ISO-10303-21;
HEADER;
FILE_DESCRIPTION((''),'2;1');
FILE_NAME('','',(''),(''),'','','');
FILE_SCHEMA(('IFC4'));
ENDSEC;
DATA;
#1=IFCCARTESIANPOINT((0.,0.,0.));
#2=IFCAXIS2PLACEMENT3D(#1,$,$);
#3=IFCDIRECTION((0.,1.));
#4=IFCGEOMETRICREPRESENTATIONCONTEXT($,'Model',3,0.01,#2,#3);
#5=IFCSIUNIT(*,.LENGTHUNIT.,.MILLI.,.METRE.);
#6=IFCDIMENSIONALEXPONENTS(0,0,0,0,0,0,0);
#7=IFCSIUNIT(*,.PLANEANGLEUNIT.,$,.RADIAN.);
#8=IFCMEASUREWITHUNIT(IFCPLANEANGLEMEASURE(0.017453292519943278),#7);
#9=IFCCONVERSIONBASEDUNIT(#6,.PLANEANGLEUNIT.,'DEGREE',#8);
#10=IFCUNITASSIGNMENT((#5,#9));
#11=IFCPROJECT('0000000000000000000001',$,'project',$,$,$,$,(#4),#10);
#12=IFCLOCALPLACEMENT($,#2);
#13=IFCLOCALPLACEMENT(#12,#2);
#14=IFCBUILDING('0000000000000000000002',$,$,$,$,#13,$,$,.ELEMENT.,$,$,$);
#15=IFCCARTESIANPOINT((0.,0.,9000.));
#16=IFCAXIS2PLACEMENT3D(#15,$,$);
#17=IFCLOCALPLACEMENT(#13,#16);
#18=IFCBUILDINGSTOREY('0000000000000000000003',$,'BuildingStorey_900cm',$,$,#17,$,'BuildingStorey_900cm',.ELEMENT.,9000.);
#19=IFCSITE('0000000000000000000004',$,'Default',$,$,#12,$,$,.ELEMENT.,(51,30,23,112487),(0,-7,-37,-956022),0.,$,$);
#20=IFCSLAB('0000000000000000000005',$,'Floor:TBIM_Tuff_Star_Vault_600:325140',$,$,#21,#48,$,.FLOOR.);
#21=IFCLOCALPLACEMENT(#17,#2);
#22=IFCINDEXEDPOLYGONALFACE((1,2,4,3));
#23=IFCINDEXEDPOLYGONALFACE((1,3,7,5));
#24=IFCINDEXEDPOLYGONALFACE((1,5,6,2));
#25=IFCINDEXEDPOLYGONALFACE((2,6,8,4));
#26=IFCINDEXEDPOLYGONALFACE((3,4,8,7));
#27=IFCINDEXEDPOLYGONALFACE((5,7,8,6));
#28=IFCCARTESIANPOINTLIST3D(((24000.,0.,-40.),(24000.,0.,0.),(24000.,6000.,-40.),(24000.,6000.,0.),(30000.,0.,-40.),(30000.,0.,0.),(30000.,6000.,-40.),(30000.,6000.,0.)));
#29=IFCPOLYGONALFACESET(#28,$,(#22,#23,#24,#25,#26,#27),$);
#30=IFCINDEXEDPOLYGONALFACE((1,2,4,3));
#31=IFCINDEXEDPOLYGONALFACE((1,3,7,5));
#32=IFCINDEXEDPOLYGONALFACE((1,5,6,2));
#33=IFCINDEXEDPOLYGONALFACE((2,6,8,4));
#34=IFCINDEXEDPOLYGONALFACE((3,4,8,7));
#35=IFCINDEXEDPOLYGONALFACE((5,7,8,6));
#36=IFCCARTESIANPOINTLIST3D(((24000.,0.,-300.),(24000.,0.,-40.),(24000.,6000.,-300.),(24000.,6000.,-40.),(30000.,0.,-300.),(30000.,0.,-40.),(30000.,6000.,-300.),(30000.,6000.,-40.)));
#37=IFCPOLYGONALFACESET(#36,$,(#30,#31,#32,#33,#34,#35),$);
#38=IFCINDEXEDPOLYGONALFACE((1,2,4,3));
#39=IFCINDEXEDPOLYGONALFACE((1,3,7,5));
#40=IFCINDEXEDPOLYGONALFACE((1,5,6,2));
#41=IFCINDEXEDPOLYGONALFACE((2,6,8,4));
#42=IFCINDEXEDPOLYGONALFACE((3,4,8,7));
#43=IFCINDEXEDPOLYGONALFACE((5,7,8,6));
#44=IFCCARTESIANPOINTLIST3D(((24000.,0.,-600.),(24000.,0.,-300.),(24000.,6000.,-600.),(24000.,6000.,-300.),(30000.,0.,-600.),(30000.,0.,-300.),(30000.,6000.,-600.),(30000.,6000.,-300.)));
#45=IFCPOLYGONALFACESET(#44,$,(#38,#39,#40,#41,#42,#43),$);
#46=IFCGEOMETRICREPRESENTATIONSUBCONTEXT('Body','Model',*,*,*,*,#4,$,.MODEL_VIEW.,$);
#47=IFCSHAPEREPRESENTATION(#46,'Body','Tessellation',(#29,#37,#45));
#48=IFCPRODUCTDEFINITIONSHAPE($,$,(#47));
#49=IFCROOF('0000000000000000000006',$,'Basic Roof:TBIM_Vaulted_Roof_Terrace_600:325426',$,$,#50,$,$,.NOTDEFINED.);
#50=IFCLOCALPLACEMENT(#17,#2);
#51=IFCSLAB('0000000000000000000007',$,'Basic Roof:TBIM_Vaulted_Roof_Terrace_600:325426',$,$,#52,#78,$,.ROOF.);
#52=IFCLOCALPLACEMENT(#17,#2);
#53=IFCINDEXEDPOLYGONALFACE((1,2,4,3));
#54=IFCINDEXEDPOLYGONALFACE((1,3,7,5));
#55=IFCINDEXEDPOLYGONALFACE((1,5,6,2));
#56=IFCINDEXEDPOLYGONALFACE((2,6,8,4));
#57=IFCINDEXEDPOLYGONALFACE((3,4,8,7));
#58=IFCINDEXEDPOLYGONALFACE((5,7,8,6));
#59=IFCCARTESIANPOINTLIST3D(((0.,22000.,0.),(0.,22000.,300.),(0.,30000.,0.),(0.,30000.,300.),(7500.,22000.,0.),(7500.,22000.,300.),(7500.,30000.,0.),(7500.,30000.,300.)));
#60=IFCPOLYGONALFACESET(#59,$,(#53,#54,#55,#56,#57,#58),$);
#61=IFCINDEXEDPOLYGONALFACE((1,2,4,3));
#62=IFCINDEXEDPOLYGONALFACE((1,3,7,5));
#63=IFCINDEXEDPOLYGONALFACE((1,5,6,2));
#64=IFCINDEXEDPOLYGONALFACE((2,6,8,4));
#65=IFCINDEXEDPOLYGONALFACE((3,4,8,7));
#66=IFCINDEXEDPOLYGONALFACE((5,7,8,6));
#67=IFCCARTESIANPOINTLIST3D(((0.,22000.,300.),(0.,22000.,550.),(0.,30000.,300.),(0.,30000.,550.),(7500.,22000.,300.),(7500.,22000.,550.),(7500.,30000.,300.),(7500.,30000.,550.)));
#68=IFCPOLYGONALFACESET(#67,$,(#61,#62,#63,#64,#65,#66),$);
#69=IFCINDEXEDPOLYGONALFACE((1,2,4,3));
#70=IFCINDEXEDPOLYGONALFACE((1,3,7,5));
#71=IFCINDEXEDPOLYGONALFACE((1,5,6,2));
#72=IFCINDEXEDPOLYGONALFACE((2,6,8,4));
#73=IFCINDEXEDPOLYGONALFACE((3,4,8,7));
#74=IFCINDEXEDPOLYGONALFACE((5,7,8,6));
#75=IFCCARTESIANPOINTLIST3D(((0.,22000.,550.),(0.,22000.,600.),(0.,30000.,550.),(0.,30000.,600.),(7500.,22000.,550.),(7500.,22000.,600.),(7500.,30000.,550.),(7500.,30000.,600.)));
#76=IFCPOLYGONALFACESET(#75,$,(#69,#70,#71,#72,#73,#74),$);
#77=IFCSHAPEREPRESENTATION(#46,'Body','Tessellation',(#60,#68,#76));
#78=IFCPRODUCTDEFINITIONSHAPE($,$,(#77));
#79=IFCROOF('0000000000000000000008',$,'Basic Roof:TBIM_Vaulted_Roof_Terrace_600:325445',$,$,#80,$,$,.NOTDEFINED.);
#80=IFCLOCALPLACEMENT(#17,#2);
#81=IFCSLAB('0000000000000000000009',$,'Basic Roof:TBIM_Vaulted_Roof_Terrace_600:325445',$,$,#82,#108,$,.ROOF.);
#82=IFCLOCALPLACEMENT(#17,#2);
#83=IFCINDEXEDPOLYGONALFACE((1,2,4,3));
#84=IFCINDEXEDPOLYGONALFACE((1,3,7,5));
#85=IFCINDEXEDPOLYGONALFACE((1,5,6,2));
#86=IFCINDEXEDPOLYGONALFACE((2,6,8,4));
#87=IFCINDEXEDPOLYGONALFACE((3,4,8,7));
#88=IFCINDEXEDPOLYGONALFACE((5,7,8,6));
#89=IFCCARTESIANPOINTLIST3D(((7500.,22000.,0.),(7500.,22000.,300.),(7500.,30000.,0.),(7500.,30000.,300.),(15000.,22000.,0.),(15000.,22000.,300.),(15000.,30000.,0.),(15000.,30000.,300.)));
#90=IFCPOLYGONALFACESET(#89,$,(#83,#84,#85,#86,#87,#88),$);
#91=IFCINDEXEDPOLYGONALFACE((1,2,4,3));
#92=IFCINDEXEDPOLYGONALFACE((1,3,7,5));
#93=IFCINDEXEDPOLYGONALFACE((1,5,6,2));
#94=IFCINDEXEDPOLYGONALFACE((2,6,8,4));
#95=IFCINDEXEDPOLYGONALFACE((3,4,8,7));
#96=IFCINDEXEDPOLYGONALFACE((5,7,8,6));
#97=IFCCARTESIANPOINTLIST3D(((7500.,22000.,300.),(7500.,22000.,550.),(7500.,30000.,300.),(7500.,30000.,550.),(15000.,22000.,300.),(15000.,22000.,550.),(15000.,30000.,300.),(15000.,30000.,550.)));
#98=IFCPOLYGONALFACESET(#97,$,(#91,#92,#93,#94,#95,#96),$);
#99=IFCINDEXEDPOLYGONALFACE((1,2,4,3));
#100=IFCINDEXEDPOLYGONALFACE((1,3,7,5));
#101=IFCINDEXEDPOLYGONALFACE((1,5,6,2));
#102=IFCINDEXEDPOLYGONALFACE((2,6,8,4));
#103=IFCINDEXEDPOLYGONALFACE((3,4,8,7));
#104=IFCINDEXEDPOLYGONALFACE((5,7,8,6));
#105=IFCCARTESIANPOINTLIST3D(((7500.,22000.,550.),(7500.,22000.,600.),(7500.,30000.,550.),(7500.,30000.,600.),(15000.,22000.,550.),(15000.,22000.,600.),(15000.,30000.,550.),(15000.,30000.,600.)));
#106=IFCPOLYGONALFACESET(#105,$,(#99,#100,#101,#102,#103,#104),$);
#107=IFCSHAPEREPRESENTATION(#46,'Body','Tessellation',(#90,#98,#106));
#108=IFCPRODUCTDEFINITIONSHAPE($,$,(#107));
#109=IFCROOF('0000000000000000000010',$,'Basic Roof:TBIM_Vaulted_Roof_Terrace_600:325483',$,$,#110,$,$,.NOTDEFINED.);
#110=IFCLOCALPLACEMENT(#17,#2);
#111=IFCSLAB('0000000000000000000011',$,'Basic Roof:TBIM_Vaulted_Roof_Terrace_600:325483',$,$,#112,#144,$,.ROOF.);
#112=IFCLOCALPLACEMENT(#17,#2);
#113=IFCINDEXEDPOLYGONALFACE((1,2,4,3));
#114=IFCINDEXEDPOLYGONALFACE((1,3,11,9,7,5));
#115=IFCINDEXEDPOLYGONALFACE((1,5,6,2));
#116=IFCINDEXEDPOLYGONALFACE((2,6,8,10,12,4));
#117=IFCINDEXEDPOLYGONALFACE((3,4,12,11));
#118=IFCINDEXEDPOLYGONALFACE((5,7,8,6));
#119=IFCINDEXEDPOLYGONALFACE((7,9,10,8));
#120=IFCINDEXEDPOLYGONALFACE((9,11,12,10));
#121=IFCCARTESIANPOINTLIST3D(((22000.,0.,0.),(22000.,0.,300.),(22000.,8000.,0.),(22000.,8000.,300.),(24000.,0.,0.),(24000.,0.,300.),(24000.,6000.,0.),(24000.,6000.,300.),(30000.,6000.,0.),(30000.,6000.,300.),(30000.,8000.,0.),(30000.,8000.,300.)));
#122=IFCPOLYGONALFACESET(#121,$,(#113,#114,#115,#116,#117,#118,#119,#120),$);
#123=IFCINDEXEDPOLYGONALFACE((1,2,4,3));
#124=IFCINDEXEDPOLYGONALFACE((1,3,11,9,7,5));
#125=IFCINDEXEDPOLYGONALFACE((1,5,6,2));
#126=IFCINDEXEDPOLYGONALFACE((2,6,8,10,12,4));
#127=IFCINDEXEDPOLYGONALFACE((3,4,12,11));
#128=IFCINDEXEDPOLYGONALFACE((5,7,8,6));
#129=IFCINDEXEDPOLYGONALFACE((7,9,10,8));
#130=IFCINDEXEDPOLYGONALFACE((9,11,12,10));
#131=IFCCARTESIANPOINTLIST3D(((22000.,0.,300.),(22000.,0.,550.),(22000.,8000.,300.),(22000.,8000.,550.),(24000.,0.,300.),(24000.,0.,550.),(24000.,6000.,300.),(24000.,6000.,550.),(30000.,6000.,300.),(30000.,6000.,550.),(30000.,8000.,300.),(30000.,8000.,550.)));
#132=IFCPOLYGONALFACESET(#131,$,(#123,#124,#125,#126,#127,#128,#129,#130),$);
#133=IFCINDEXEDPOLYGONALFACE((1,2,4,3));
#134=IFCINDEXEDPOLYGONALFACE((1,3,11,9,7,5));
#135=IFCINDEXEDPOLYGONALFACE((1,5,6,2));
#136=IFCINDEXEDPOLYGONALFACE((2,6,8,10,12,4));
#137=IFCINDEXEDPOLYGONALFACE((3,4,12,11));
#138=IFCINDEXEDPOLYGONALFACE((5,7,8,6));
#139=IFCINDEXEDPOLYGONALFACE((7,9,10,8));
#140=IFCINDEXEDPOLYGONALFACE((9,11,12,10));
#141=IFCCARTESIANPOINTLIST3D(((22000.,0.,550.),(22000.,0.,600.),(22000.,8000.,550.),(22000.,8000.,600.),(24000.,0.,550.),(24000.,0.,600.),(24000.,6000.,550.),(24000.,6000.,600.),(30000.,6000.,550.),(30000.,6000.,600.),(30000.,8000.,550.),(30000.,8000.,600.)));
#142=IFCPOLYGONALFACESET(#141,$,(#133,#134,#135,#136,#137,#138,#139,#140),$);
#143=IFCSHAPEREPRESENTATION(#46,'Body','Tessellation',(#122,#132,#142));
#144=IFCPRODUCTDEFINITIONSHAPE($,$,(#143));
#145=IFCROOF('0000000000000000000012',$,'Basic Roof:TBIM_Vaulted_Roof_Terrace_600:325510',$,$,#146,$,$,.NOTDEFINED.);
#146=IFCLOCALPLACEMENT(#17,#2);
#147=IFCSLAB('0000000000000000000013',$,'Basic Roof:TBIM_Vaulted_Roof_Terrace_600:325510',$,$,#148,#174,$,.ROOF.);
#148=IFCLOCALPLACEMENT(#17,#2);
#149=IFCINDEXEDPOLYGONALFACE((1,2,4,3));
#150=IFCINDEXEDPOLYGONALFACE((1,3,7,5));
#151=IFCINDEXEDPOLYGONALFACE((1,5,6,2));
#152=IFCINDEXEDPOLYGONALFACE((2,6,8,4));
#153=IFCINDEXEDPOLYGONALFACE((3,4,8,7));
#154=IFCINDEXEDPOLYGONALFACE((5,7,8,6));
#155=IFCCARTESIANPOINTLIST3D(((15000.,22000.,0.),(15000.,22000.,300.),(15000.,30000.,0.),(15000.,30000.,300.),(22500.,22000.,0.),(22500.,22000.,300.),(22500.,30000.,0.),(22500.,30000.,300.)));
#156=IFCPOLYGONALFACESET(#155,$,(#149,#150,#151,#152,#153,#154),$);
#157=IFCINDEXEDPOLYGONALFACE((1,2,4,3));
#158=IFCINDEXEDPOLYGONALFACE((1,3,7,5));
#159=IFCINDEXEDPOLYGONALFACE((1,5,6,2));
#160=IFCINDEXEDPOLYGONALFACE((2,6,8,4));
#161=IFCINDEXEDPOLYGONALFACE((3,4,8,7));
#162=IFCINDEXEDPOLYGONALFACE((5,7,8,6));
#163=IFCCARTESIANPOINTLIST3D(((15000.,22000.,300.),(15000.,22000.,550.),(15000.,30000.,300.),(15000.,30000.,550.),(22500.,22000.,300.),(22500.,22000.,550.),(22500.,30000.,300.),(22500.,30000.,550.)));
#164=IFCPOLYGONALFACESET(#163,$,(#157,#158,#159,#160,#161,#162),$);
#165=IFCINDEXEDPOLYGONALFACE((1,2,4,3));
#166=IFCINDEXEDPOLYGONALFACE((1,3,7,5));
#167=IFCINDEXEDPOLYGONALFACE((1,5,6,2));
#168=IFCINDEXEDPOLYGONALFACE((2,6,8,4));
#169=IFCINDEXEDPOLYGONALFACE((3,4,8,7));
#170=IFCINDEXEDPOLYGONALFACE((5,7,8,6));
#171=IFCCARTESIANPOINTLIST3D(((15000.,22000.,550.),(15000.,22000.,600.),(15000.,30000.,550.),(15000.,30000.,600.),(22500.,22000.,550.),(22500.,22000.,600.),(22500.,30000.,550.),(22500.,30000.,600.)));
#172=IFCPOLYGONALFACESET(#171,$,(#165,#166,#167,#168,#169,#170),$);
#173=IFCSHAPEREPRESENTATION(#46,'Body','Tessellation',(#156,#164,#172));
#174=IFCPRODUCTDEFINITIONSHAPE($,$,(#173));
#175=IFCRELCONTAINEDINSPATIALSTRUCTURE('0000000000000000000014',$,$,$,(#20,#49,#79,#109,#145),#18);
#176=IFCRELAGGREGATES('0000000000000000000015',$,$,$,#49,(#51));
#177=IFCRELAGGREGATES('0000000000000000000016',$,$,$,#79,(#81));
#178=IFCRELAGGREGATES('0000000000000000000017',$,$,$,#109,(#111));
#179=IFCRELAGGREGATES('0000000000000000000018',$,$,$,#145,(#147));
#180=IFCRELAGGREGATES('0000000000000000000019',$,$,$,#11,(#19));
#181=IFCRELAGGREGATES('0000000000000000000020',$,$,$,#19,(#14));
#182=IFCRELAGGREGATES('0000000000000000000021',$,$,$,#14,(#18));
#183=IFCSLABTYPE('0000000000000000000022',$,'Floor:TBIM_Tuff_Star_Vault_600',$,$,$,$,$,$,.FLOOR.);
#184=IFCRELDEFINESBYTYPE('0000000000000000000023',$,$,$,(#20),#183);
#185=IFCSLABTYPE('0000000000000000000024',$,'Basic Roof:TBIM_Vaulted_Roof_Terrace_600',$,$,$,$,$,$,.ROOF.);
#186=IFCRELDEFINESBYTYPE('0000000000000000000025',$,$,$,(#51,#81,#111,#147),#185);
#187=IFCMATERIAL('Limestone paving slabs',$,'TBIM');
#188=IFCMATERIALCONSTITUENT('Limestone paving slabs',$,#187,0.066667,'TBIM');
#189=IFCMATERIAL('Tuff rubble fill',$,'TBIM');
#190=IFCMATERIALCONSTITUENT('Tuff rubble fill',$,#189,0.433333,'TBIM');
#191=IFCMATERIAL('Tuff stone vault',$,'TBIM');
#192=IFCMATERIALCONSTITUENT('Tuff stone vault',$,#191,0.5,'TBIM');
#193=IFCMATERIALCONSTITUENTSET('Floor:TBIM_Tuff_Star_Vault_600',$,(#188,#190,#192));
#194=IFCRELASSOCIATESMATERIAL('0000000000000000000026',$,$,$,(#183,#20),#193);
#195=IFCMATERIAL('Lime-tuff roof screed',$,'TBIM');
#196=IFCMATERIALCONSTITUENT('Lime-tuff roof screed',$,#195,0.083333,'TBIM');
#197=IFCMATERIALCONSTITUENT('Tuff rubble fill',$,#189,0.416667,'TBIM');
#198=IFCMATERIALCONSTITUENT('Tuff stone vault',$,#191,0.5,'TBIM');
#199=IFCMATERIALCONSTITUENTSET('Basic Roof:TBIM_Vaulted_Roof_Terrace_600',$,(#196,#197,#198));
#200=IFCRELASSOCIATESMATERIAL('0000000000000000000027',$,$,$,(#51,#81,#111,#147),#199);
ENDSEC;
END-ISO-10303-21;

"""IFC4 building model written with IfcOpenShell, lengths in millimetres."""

from ifc_helpers import new_model, entity, si_unit, converted_unit, direction, frame, origin, place, context, subcontext, project, spatial, indexed_curve, outline, extrude, material, constituent, constituent_set, type_object, element, aggregate, save


model = new_model("IFC4")

# Units and contexts
model_context = context("Model", 3, precision=0.01, world=origin(), true_north=direction((0.0, 1.0)))
body_context = subcontext(model_context, "Body", "Model", "MODEL_VIEW")
ifc_project = project(units=[si_unit("LENGTHUNIT", "METRE", prefix="MILLI"), converted_unit("PLANEANGLEUNIT", "DEGREE", entity("IfcPlaneAngleMeasure", 0.017453292519943278), si_unit("PLANEANGLEUNIT", "RADIAN"), dimensions=[0, 0, 0, 0, 0, 0, 0])], contexts=[model_context])

# Site, building, storey
site_placement = place(None, origin())
site = spatial("IfcSite", under=ifc_project, at=site_placement, Name="Default", CompositionType="ELEMENT", RefLatitude=(51, 30, 23, 112487), RefLongitude=(0, -7, -37, -956022), RefElevation=0.0)
building_placement = place(site_placement, origin())
building = spatial("IfcBuilding", under=site, at=building_placement, CompositionType="ELEMENT")
storey_placement = place(building_placement, frame((0.0, 0.0, 9000.0)))
storey = spatial("IfcBuildingStorey", under=building, at=storey_placement, Name="BuildingStorey_900cm", LongName="BuildingStorey_900cm", CompositionType="ELEMENT", Elevation=9000.0)

# Slab
ifc_material_1 = material(Name="Limestone paving slabs", Category="TBIM")
ifc_constituent_1 = constituent(ifc_material_1, Name="Limestone paving slabs", Category="TBIM", fraction=0.066667)
ifc_material_2 = material(Name="Tuff rubble fill", Category="TBIM")
ifc_constituent_2 = constituent(ifc_material_2, Name="Tuff rubble fill", Category="TBIM", fraction=0.433333)
ifc_material_3 = material(Name="Tuff stone vault", Category="TBIM")
ifc_constituent_3 = constituent(ifc_material_3, Name="Tuff stone vault", Category="TBIM", fraction=0.5)
ifc_constituent_set_1 = constituent_set(constituents=[ifc_constituent_1, ifc_constituent_2, ifc_constituent_3], Name="Floor:TBIM_Tuff_Star_Vault_600")
slab_type_1 = type_object("IfcSlabType", Name="Floor:TBIM_Tuff_Star_Vault_600", PredefinedType="FLOOR", material=ifc_constituent_set_1)
slab_1_placement = place(storey_placement, origin())
element("IfcSlab", 1, at=slab_1_placement, inside=storey, type_object=slab_type_1, material=ifc_constituent_set_1, Name="Floor:TBIM_Tuff_Star_Vault_600:325140", PredefinedType="FLOOR", context=body_context, shape_type="SweptSolid", body=[
    extrude(outline(indexed_curve([(-3000.0, -3000.0), (3000.0, -3000.0), (3000.0, 3000.0), (-3000.0, 3000.0), (-3000.0, -3000.0)], self_intersect=False)), frame((27000.0, 3000.0, -40.0), z_axis=(0.0, 0.0, 1.0), x_axis=(-1.0, 0.0, 0.0)), (0.0, 0.0, 1.0), 40.0),
    extrude(outline(indexed_curve([(-3000.0, -3000.0), (3000.0, -3000.0), (3000.0, 3000.0), (-3000.0, 3000.0), (-3000.0, -3000.0)], self_intersect=False)), frame((27000.0, 3000.0, -300.0), z_axis=(0.0, 0.0, 1.0), x_axis=(-1.0, 0.0, 0.0)), (0.0, 0.0, 1.0), 260.0),
    extrude(outline(indexed_curve([(-3000.0, -3000.0), (3000.0, -3000.0), (3000.0, 3000.0), (-3000.0, 3000.0), (-3000.0, -3000.0)], self_intersect=False)), frame((27000.0, 3000.0, -600.0), z_axis=(0.0, 0.0, 1.0), x_axis=(-1.0, 0.0, 0.0)), (0.0, 0.0, 1.0), 300.0),
])

# Roofs, slabs
roof_1_placement = place(storey_placement, frame((0.0, 22000.0, 0.0)))
roof_1 = element("IfcRoof", 2, at=roof_1_placement, inside=storey, Name="Basic Roof:TBIM_Vaulted_Roof_Terrace_600:325426", PredefinedType="NOTDEFINED")
ifc_material_4 = material(Name="Lime-tuff roof screed", Category="TBIM")
ifc_constituent_4 = constituent(ifc_material_4, Name="Lime-tuff roof screed", Category="TBIM", fraction=0.083333)
ifc_constituent_5 = constituent(ifc_material_2, Name="Tuff rubble fill", Category="TBIM", fraction=0.416667)
ifc_constituent_6 = constituent(ifc_material_3, Name="Tuff stone vault", Category="TBIM", fraction=0.5)
ifc_constituent_set_2 = constituent_set(constituents=[ifc_constituent_4, ifc_constituent_5, ifc_constituent_6], Name="Basic Roof:TBIM_Vaulted_Roof_Terrace_600")
slab_type_2 = type_object("IfcSlabType", Name="Basic Roof:TBIM_Vaulted_Roof_Terrace_600", PredefinedType="ROOF")
slab_2_placement = place(roof_1_placement, origin())
slab_2 = element("IfcSlab", 3, at=slab_2_placement, type_object=slab_type_2, material=ifc_constituent_set_2, Name="Basic Roof:TBIM_Vaulted_Roof_Terrace_600:325426", PredefinedType="ROOF", context=body_context, shape_type="SweptSolid", body=[
    extrude(outline(indexed_curve([(-3750.0, 4000.0), (-3750.0, -4000.0), (3750.0, -4000.0), (3750.0, 4000.0), (-3750.0, 4000.0)], self_intersect=False)), frame((3750.0, 4000.0, 0.0)), (0.0, 0.0, 1.0), 300.0),
    extrude(outline(indexed_curve([(-3750.0, 4000.0), (-3750.0, -4000.0), (3750.0, -4000.0), (3750.0, 4000.0), (-3750.0, 4000.0)], self_intersect=False)), frame((3750.0, 4000.0, 300.0)), (0.0, 0.0, 1.0), 250.0),
    extrude(outline(indexed_curve([(-3750.0, 4000.0), (-3750.0, -4000.0), (3750.0, -4000.0), (3750.0, 4000.0), (-3750.0, 4000.0)], self_intersect=False)), frame((3750.0, 4000.0, 550.0)), (0.0, 0.0, 1.0), 50.0),
])
aggregate(roof_1, [slab_2])
roof_2_placement = place(storey_placement, frame((7500.0, 22000.0, 0.0)))
roof_2 = element("IfcRoof", 4, at=roof_2_placement, inside=storey, Name="Basic Roof:TBIM_Vaulted_Roof_Terrace_600:325445", PredefinedType="NOTDEFINED")
slab_3_placement = place(roof_2_placement, origin())
slab_3 = element("IfcSlab", 5, at=slab_3_placement, type_object=slab_type_2, material=ifc_constituent_set_2, Name="Basic Roof:TBIM_Vaulted_Roof_Terrace_600:325445", PredefinedType="ROOF", context=body_context, shape_type="SweptSolid", body=[
    extrude(outline(indexed_curve([(-3750.0, 4000.0), (-3750.0, -4000.0), (3750.0, -4000.0), (3750.0, 4000.0), (-3750.0, 4000.0)], self_intersect=False)), frame((3750.0, 4000.0, 0.0)), (0.0, 0.0, 1.0), 300.0),
    extrude(outline(indexed_curve([(-3750.0, 4000.0), (-3750.0, -4000.0), (3750.0, -4000.0), (3750.0, 4000.0), (-3750.0, 4000.0)], self_intersect=False)), frame((3750.0, 4000.0, 300.0)), (0.0, 0.0, 1.0), 250.0),
    extrude(outline(indexed_curve([(-3750.0, 4000.0), (-3750.0, -4000.0), (3750.0, -4000.0), (3750.0, 4000.0), (-3750.0, 4000.0)], self_intersect=False)), frame((3750.0, 4000.0, 550.0)), (0.0, 0.0, 1.0), 50.0),
])
aggregate(roof_2, [slab_3])
roof_3_placement = place(storey_placement, frame((22000.0, 0.0, 0.0)))
roof_3 = element("IfcRoof", 6, at=roof_3_placement, inside=storey, Name="Basic Roof:TBIM_Vaulted_Roof_Terrace_600:325483", PredefinedType="NOTDEFINED")
slab_4_placement = place(roof_3_placement, origin())
slab_4 = element("IfcSlab", 7, at=slab_4_placement, type_object=slab_type_2, material=ifc_constituent_set_2, Name="Basic Roof:TBIM_Vaulted_Roof_Terrace_600:325483", PredefinedType="ROOF", context=body_context, shape_type="SweptSolid", body=[
    extrude(outline(indexed_curve([(-4000.0, -4000.0), (-2000.0, -4000.0), (-2000.0, 2000.0), (4000.0, 2000.0), (4000.0, 4000.0), (-4000.0, 4000.0), (-4000.0, -4000.0)], self_intersect=False)), frame((4000.0, 4000.0, 0.0)), (0.0, 0.0, 1.0), 300.0),
    extrude(outline(indexed_curve([(-4000.0, -4000.0), (-2000.0, -4000.0), (-2000.0, 2000.0), (4000.0, 2000.0), (4000.0, 4000.0), (-4000.0, 4000.0), (-4000.0, -4000.0)], self_intersect=False)), frame((4000.0, 4000.0, 300.0)), (0.0, 0.0, 1.0), 250.0),
    extrude(outline(indexed_curve([(-4000.0, -4000.0), (-2000.0, -4000.0), (-2000.0, 2000.0), (4000.0, 2000.0), (4000.0, 4000.0), (-4000.0, 4000.0), (-4000.0, -4000.0)], self_intersect=False)), frame((4000.0, 4000.0, 550.0)), (0.0, 0.0, 1.0), 50.0),
])
aggregate(roof_3, [slab_4])
roof_4_placement = place(storey_placement, frame((15000.0, 22000.0, 0.0)))
roof_4 = element("IfcRoof", 8, at=roof_4_placement, inside=storey, Name="Basic Roof:TBIM_Vaulted_Roof_Terrace_600:325510", PredefinedType="NOTDEFINED")
slab_5_placement = place(roof_4_placement, origin())
slab_5 = element("IfcSlab", 9, at=slab_5_placement, type_object=slab_type_2, material=ifc_constituent_set_2, Name="Basic Roof:TBIM_Vaulted_Roof_Terrace_600:325510", PredefinedType="ROOF", context=body_context, shape_type="SweptSolid", body=[
    extrude(outline(indexed_curve([(-3750.0, 4000.0), (-3750.0, -4000.0), (3750.0, -4000.0), (3750.0, 4000.0), (-3750.0, 4000.0)], self_intersect=False)), frame((3750.0, 4000.0, 0.0)), (0.0, 0.0, 1.0), 300.0),
    extrude(outline(indexed_curve([(-3750.0, 4000.0), (-3750.0, -4000.0), (3750.0, -4000.0), (3750.0, 4000.0), (-3750.0, 4000.0)], self_intersect=False)), frame((3750.0, 4000.0, 300.0)), (0.0, 0.0, 1.0), 250.0),
    extrude(outline(indexed_curve([(-3750.0, 4000.0), (-3750.0, -4000.0), (3750.0, -4000.0), (3750.0, 4000.0), (-3750.0, 4000.0)], self_intersect=False)), frame((3750.0, 4000.0, 550.0)), (0.0, 0.0, 1.0), 50.0),
])
aggregate(roof_4, [slab_5])

save(model, "model.ifc")
